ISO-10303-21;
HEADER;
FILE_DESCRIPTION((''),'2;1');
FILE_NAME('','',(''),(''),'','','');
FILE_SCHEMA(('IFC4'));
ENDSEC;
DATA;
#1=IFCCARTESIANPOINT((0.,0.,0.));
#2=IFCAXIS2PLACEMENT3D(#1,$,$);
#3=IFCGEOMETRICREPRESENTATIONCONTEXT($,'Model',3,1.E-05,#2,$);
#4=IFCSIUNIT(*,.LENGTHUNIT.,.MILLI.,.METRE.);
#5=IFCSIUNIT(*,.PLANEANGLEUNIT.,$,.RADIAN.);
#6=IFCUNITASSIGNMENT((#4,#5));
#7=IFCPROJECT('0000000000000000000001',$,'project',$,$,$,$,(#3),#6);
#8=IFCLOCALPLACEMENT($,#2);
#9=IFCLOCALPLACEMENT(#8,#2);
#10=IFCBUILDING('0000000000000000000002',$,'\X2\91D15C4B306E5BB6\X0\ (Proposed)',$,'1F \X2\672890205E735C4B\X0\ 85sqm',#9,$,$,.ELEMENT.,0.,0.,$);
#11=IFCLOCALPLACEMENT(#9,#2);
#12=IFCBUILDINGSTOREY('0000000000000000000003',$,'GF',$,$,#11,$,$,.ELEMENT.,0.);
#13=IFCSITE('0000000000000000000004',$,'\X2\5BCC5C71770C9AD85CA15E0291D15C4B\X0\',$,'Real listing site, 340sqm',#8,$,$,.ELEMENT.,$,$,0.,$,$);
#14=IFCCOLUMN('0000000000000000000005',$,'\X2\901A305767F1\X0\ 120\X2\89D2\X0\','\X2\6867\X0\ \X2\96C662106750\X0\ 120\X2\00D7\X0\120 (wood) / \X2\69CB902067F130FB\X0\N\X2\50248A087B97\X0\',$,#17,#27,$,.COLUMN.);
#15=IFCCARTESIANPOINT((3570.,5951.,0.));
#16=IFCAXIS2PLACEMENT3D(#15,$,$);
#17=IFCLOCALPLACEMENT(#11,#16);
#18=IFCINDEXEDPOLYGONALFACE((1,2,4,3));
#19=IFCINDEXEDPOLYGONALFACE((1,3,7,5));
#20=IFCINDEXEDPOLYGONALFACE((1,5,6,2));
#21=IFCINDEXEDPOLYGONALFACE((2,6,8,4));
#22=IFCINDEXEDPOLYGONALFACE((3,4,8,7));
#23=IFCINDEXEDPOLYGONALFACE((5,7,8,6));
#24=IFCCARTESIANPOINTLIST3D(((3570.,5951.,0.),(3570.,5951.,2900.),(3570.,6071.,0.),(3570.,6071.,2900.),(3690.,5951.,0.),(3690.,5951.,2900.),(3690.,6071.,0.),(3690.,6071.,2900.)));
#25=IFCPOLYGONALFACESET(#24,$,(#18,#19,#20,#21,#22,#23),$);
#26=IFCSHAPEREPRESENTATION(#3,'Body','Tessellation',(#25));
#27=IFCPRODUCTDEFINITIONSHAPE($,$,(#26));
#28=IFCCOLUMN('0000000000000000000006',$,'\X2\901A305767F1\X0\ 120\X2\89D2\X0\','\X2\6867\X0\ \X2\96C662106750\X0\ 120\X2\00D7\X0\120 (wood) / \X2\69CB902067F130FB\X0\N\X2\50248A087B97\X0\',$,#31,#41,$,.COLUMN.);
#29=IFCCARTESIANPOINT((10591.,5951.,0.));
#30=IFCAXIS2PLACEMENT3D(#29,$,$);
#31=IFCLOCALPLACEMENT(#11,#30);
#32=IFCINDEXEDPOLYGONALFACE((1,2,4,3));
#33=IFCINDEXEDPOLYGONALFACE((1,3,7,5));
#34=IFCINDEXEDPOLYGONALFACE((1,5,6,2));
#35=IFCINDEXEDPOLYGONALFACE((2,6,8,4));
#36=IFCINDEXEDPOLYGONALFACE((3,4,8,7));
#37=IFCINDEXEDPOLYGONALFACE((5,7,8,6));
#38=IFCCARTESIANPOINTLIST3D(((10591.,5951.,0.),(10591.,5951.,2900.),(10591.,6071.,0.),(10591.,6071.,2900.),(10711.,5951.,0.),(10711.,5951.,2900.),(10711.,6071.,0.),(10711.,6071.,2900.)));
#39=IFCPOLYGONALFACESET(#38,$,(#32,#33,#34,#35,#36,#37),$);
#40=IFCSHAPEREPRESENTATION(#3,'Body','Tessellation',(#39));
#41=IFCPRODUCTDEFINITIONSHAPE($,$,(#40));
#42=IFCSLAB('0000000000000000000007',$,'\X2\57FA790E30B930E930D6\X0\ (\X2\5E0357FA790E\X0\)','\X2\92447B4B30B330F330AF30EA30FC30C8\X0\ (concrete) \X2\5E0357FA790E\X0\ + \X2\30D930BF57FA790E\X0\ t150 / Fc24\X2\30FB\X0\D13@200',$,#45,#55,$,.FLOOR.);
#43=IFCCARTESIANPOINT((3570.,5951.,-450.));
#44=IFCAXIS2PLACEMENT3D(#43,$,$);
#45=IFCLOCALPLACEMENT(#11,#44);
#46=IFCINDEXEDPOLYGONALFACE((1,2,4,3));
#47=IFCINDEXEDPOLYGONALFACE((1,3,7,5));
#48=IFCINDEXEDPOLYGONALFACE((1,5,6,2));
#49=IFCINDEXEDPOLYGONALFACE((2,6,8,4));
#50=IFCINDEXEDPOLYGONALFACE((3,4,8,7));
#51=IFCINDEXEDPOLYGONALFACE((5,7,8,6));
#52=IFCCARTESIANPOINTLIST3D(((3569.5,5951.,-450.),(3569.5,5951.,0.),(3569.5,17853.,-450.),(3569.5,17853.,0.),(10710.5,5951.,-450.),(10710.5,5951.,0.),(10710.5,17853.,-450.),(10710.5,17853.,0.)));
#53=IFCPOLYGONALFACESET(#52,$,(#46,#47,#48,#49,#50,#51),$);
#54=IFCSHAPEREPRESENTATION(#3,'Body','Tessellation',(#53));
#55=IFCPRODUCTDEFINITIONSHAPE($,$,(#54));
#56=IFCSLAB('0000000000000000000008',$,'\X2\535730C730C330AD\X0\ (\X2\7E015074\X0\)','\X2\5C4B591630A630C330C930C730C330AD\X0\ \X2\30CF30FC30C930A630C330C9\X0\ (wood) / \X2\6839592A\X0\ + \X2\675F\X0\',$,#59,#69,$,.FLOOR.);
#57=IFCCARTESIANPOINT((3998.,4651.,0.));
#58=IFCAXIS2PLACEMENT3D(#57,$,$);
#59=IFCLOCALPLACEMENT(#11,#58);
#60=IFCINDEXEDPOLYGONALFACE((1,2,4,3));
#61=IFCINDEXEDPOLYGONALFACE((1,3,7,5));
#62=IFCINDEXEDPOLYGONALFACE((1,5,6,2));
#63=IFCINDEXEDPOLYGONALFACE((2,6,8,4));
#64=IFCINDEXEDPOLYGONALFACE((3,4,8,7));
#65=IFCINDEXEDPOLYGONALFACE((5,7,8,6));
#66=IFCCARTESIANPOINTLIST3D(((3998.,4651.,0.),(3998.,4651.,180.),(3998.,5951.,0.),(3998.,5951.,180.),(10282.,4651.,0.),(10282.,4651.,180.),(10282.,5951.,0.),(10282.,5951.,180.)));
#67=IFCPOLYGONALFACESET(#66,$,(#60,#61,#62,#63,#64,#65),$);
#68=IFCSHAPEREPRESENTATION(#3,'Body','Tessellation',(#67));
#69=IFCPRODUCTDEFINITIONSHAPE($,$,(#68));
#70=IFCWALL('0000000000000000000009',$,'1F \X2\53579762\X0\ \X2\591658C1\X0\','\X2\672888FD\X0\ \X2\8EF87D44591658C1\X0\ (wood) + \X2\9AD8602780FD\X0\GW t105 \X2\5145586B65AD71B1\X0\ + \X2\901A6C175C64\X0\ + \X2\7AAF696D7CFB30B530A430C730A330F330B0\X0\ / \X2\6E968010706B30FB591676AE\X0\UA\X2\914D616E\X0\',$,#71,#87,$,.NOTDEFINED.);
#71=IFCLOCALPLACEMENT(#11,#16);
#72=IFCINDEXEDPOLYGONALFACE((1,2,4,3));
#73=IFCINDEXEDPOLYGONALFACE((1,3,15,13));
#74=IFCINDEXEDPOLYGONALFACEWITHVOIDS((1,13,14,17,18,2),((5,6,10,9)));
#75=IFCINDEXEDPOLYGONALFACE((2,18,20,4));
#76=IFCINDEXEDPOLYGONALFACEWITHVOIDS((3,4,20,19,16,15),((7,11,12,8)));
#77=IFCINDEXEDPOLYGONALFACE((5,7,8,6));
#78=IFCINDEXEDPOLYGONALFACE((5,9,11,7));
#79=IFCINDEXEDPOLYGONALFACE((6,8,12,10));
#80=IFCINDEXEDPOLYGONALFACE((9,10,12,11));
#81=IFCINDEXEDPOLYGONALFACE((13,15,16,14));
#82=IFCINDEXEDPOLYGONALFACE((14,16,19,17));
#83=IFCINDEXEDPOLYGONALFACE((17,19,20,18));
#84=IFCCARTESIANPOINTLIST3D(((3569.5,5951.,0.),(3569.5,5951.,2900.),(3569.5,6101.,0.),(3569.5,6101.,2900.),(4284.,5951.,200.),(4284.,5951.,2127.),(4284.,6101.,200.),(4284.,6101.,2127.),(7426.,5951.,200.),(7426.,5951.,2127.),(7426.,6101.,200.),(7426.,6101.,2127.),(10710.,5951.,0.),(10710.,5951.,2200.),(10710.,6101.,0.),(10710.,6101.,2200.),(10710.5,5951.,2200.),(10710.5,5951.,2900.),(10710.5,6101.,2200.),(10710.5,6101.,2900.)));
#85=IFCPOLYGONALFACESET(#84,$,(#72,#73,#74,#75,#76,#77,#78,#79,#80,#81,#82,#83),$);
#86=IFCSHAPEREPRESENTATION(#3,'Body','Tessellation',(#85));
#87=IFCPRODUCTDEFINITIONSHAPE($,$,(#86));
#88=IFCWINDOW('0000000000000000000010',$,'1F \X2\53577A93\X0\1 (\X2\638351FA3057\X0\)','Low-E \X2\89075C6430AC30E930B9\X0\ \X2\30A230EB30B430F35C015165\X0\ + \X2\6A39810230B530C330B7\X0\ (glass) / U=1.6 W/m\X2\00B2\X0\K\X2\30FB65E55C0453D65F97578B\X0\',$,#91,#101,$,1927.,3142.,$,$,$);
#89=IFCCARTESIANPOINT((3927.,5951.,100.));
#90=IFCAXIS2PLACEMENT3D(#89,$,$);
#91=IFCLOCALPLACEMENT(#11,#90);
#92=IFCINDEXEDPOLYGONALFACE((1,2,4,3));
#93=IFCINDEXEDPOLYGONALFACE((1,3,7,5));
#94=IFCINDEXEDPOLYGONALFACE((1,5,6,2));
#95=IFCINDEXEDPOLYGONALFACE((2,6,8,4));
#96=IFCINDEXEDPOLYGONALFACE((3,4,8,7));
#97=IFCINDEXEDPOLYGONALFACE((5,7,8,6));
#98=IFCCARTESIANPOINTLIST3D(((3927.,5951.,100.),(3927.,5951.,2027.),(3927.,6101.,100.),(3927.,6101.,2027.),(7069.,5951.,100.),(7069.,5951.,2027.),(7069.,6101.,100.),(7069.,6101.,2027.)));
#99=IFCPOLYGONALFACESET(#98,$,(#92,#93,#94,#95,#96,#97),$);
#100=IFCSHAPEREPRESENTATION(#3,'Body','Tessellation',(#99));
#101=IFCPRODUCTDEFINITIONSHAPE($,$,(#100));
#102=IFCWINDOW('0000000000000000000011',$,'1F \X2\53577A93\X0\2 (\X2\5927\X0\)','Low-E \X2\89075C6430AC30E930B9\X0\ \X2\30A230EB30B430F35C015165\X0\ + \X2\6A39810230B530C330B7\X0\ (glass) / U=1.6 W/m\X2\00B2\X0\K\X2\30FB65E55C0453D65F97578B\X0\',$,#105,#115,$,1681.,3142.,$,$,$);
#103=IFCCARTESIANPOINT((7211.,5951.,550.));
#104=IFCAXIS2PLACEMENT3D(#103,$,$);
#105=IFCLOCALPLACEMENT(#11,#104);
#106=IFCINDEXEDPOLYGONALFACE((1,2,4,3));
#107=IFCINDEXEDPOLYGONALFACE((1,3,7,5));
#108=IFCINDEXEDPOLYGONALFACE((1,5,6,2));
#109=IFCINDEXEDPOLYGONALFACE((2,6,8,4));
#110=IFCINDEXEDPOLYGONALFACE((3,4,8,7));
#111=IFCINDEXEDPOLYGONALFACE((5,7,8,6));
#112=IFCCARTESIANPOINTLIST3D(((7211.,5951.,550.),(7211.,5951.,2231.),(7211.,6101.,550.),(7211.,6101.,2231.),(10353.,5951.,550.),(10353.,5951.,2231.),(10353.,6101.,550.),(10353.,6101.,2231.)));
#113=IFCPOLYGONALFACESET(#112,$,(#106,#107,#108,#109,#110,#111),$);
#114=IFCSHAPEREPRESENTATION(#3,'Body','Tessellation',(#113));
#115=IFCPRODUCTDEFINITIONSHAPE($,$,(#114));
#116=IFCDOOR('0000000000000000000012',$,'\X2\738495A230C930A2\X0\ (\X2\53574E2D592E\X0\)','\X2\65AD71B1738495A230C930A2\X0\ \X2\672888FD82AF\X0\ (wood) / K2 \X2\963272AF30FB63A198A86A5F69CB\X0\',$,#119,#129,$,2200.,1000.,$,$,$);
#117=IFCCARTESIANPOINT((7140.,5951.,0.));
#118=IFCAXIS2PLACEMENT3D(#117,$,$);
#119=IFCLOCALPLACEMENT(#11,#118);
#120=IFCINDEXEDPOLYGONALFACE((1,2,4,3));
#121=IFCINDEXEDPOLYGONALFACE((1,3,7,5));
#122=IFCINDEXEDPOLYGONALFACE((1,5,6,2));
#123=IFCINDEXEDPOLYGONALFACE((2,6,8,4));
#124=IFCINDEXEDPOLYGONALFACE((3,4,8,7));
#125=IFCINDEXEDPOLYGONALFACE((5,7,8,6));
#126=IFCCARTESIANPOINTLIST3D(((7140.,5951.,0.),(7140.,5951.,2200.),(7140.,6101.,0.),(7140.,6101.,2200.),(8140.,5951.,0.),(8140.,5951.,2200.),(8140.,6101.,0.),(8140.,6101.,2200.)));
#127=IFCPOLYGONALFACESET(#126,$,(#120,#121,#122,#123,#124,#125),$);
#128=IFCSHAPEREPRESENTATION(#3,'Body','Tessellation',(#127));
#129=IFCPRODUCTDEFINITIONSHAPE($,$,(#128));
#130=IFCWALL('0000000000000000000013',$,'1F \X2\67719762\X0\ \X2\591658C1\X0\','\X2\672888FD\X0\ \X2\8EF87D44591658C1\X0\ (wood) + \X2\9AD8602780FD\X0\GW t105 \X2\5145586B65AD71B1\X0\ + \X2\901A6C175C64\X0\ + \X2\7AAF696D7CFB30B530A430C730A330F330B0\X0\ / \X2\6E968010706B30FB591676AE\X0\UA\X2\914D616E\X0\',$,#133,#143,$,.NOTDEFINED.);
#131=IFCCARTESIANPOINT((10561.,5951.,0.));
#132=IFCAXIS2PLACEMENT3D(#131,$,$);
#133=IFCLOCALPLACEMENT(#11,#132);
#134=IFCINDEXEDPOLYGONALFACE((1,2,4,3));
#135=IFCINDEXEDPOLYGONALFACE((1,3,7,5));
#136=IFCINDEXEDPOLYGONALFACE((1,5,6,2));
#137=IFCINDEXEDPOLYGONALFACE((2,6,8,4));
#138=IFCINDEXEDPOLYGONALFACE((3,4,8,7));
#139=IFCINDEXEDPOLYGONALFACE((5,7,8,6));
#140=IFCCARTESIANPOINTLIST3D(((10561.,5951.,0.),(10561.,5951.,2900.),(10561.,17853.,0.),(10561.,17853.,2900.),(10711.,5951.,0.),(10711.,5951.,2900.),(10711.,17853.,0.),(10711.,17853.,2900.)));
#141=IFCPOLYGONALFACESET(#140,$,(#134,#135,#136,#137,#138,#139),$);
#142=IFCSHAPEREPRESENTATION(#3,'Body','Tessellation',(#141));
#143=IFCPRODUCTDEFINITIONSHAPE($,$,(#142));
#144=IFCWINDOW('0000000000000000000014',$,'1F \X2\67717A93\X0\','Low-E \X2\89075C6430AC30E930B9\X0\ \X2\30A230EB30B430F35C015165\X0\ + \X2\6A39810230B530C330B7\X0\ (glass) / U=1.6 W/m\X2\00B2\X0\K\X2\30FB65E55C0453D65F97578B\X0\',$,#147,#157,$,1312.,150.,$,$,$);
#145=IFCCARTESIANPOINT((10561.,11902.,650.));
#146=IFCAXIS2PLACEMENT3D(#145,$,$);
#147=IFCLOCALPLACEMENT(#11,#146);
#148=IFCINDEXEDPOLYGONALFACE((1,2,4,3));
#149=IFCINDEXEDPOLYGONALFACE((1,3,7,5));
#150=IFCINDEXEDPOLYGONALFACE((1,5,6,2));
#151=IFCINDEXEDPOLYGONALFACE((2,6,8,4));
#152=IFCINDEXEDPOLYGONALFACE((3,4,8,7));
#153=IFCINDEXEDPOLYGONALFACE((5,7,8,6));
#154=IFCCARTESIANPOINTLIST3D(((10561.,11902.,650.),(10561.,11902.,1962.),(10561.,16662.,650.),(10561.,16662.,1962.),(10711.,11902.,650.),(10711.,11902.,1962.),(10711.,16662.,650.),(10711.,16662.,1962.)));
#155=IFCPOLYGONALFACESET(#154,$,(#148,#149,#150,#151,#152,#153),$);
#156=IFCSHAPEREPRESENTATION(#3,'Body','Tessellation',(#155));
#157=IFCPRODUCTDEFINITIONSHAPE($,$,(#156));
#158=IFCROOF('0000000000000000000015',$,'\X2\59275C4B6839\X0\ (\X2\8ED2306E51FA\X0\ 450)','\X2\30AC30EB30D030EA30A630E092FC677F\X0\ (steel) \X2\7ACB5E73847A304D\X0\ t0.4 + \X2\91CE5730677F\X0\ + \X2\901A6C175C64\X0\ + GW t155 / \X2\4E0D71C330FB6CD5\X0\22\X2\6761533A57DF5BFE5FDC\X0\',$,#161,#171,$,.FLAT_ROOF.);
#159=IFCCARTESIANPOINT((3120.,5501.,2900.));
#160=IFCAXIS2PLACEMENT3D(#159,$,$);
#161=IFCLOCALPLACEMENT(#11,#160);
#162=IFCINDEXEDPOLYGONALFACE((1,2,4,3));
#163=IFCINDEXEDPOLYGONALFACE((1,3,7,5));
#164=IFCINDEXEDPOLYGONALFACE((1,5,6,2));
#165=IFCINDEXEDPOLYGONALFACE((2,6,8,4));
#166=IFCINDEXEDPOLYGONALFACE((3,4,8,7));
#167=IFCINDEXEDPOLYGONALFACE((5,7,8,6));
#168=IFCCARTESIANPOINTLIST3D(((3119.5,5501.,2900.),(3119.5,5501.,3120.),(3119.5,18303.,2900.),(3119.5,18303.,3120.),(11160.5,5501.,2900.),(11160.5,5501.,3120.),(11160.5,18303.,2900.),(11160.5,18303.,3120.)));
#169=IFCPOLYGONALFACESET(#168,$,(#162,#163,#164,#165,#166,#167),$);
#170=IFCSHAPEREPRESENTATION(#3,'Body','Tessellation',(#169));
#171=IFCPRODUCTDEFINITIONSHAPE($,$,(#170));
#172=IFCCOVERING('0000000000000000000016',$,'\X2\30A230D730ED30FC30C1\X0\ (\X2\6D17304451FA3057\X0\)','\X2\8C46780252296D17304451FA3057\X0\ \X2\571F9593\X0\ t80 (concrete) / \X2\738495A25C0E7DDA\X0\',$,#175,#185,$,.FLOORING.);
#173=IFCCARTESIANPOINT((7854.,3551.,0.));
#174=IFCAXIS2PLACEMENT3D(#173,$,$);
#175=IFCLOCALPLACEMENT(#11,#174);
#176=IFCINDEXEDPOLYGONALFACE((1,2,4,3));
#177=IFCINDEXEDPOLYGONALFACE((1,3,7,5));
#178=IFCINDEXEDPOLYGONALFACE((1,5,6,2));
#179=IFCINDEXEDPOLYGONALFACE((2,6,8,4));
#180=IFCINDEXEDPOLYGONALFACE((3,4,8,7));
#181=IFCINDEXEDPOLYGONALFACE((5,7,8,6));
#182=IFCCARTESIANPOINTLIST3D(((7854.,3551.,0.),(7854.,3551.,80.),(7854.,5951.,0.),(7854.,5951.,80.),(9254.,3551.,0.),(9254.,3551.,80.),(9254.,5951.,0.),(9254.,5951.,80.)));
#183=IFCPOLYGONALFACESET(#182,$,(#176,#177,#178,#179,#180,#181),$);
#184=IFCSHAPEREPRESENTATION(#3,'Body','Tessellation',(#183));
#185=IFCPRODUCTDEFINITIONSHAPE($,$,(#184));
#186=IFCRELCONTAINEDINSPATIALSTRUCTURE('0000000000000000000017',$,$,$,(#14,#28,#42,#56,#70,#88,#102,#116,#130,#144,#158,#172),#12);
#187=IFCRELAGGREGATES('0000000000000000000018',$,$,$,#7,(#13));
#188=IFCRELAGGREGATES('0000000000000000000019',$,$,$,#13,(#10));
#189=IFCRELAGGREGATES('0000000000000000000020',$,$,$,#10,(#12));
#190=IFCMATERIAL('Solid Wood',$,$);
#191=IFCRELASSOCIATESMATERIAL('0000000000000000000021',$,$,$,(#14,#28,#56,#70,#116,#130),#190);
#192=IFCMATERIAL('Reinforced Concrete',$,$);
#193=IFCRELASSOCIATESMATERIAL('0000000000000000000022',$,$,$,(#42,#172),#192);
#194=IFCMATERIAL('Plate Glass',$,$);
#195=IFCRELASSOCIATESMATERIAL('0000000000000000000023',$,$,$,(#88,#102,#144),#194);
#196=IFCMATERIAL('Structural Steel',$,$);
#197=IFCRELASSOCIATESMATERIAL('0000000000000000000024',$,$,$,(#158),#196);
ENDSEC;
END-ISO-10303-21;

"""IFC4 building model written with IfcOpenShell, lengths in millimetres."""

from ifc_helpers import new_model, si_unit, frame, frame_2d, origin, place, context, project, spatial, rectangle, extrude, material, element, fill, save


model = new_model("IFC4")

# Units and contexts
model_context = context("Model", 3, precision=1e-05, world=origin())
ifc_project = project(units=[si_unit("LENGTHUNIT", "METRE", prefix="MILLI"), si_unit("PLANEANGLEUNIT", "RADIAN")], contexts=[model_context])

# Site, building, storey
site_placement = place(None, origin())
site = spatial("IfcSite", under=ifc_project, at=site_placement, Name="富山県高岡市金屋", ObjectType="Real listing site, 340sqm", CompositionType="ELEMENT", RefElevation=0.0)
building_placement = place(site_placement, origin())
building = spatial("IfcBuilding", under=site, at=building_placement, Name="金屋の家 (Proposed)", ObjectType="1F 木造平屋 85sqm", CompositionType="ELEMENT", ElevationOfRefHeight=0.0, ElevationOfTerrain=0.0)
storey_placement = place(building_placement, origin())
storey = spatial("IfcBuildingStorey", under=building, at=storey_placement, Name="GF", CompositionType="ELEMENT", Elevation=0.0)

# Columns
ifc_material_1 = material(Name="Solid Wood")
column_1_placement = place(storey_placement, frame((3570.0, 5951.0, 0.0)))
element("IfcColumn", 1, at=column_1_placement, inside=storey, material=ifc_material_1, Name="通し柱 120角", Description="桧 集成材 120×120 (wood) / 構造柱・N値計算", PredefinedType="COLUMN", context=model_context, shape_type="SweptSolid", body=[
    extrude(rectangle(XDim=120.0, YDim=120.0, at=frame_2d((60.0, 60.0))), frame((3570.0, 5951.0, 0.0)), (0.0, 0.0, 1.0), 2900.0),
])
column_2_placement = place(storey_placement, frame((10591.0, 5951.0, 0.0)))
element("IfcColumn", 2, at=column_2_placement, inside=storey, material=ifc_material_1, Name="通し柱 120角", Description="桧 集成材 120×120 (wood) / 構造柱・N値計算", PredefinedType="COLUMN", context=model_context, shape_type="SweptSolid", body=[
    extrude(rectangle(XDim=120.0, YDim=120.0, at=frame_2d((60.0, 60.0))), frame((10591.0, 5951.0, 0.0)), (0.0, 0.0, 1.0), 2900.0),
])

# Slabs
ifc_material_2 = material(Name="Reinforced Concrete")
slab_1_placement = place(storey_placement, frame((3570.0, 5951.0, -450.0)))
element("IfcSlab", 3, at=slab_1_placement, inside=storey, material=ifc_material_2, Name="基礎スラブ (布基礎)", Description="鉄筋コンクリート (concrete) 布基礎 + ベタ基礎 t150 / Fc24・D13@200", PredefinedType="FLOOR", context=model_context, shape_type="SweptSolid", body=[
    extrude(rectangle(XDim=7141.0, YDim=11902.0, at=frame_2d((3570.0, 5951.0))), frame((3570.0, 5951.0, -450.0)), (0.0, 0.0, 1.0), 450.0),
])
slab_2_placement = place(storey_placement, frame((3998.0, 4651.0, 0.0)))
element("IfcSlab", 4, at=slab_2_placement, inside=storey, material=ifc_material_1, Name="南デッキ (縁側)", Description="屋外ウッドデッキ ハードウッド (wood) / 根太 + 束", PredefinedType="FLOOR", context=model_context, shape_type="SweptSolid", body=[
    extrude(rectangle(XDim=6284.0, YDim=1300.0, at=frame_2d((3142.0, 650.0))), frame((3998.0, 4651.0, 0.0)), (0.0, 0.0, 1.0), 180.0),
])

# Wall, openings, windows, door
wall_1_placement = place(storey_placement, frame((3570.0, 5951.0, 0.0)))
wall_1 = element("IfcWall", 5, at=wall_1_placement, inside=storey, material=ifc_material_1, Name="1F 南面 外壁", Description="木製 軸組外壁 (wood) + 高性能GW t105 充填断熱 + 通気層 + 窯業系サイディング / 準耐火・外皮UA配慮", PredefinedType="NOTDEFINED", context=model_context, shape_type="SweptSolid", body=[
    extrude(rectangle(XDim=7141.0, YDim=150.0, at=frame_2d((3570.0, 75.0))), frame((3570.0, 5951.0, 0.0)), (0.0, 0.0, 1.0), 2900.0),
])
opening_1_placement = place(storey_placement, frame((3927.0, 5951.0, 100.0)))
opening_1 = element("IfcOpeningElement", 6, at=opening_1_placement, cuts=wall_1, PredefinedType="NOTDEFINED", context=model_context, shape_type="SweptSolid", body=[
    extrude(rectangle(XDim=3142.0, YDim=150.0, at=frame_2d((1571.0, 75.0))), frame((3927.0, 5951.0, 100.0)), (0.0, 0.0, 1.0), 1927.0),
])
opening_2_placement = place(storey_placement, frame((7211.0, 5951.0, 550.0)))
opening_2 = element("IfcOpeningElement", 7, at=opening_2_placement, cuts=wall_1, PredefinedType="NOTDEFINED", context=model_context, shape_type="SweptSolid", body=[
    extrude(rectangle(XDim=3142.0, YDim=150.0, at=frame_2d((1571.0, 75.0))), frame((7211.0, 5951.0, 550.0)), (0.0, 0.0, 1.0), 1681.0),
])
opening_3_placement = place(storey_placement, frame((7140.0, 5951.0, 0.0)))
opening_3 = element("IfcOpeningElement", 8, at=opening_3_placement, cuts=wall_1, PredefinedType="NOTDEFINED", context=model_context, shape_type="SweptSolid", body=[
    extrude(rectangle(XDim=1000.0, YDim=150.0, at=frame_2d((500.0, 75.0))), frame((7140.0, 5951.0, 0.0)), (0.0, 0.0, 1.0), 2200.0),
])
ifc_material_3 = material(Name="Plate Glass")
window_1_placement = place(storey_placement, frame((3927.0, 5951.0, 100.0)))
window_1 = element("IfcWindow", 9, at=window_1_placement, inside=storey, material=ifc_material_3, Name="1F 南窓1 (掃出し)", Description="Low-E 複層ガラス アルゴン封入 + 樹脂サッシ (glass) / U=1.6 W/m²K・日射取得型", OverallHeight=1927.0, OverallWidth=3142.0, context=model_context, shape_type="SweptSolid", body=[
    extrude(rectangle(XDim=3142.0, YDim=150.0, at=frame_2d((1571.0, 75.0))), frame((3927.0, 5951.0, 100.0)), (0.0, 0.0, 1.0), 1927.0),
])
fill(opening_1, window_1)
window_2_placement = place(storey_placement, frame((7211.0, 5951.0, 550.0)))
window_2 = element("IfcWindow", 10, at=window_2_placement, inside=storey, material=ifc_material_3, Name="1F 南窓2 (大)", Description="Low-E 複層ガラス アルゴン封入 + 樹脂サッシ (glass) / U=1.6 W/m²K・日射取得型", OverallHeight=1681.0, OverallWidth=3142.0, context=model_context, shape_type="SweptSolid", body=[
    extrude(rectangle(XDim=3142.0, YDim=150.0, at=frame_2d((1571.0, 75.0))), frame((7211.0, 5951.0, 550.0)), (0.0, 0.0, 1.0), 1681.0),
])
fill(opening_2, window_2)
door_placement = place(storey_placement, frame((7140.0, 5951.0, 0.0)))
door = element("IfcDoor", 11, at=door_placement, inside=storey, material=ifc_material_1, Name="玄関ドア (南中央)", Description="断熱玄関ドア 木製芯 (wood) / K2 防犯・採風機構", OverallHeight=2200.0, OverallWidth=1000.0, context=model_context, shape_type="SweptSolid", body=[
    extrude(rectangle(XDim=1000.0, YDim=150.0, at=frame_2d((500.0, 75.0))), frame((7140.0, 5951.0, 0.0)), (0.0, 0.0, 1.0), 2200.0),
])
fill(opening_3, door)

# Wall, opening, window
wall_2_placement = place(storey_placement, frame((10561.0, 5951.0, 0.0)))
wall_2 = element("IfcWall", 12, at=wall_2_placement, inside=storey, material=ifc_material_1, Name="1F 東面 外壁", Description="木製 軸組外壁 (wood) + 高性能GW t105 充填断熱 + 通気層 + 窯業系サイディング / 準耐火・外皮UA配慮", PredefinedType="NOTDEFINED", context=model_context, shape_type="SweptSolid", body=[
    extrude(rectangle(XDim=150.0, YDim=11902.0, at=frame_2d((75.0, 5951.0))), frame((10561.0, 5951.0, 0.0)), (0.0, 0.0, 1.0), 2900.0),
])
opening_4_placement = place(storey_placement, frame((10561.0, 11902.0, 650.0)))
opening_4 = element("IfcOpeningElement", 13, at=opening_4_placement, cuts=wall_2, PredefinedType="NOTDEFINED", context=model_context, shape_type="SweptSolid", body=[
    extrude(rectangle(XDim=150.0, YDim=4760.0, at=frame_2d((75.0, 2380.0))), frame((10561.0, 11902.0, 650.0)), (0.0, 0.0, 1.0), 1312.0),
])
window_3_placement = place(storey_placement, frame((10561.0, 11902.0, 650.0)))
window_3 = element("IfcWindow", 14, at=window_3_placement, inside=storey, material=ifc_material_3, Name="1F 東窓", Description="Low-E 複層ガラス アルゴン封入 + 樹脂サッシ (glass) / U=1.6 W/m²K・日射取得型", OverallHeight=1312.0, OverallWidth=150.0, context=model_context, shape_type="SweptSolid", body=[
    extrude(rectangle(XDim=150.0, YDim=4760.0, at=frame_2d((75.0, 2380.0))), frame((10561.0, 11902.0, 650.0)), (0.0, 0.0, 1.0), 1312.0),
])
fill(opening_4, window_3)

# Roof
ifc_material_4 = material(Name="Structural Steel")
roof_placement = place(storey_placement, frame((3120.0, 5501.0, 2900.0)))
element("IfcRoof", 15, at=roof_placement, inside=storey, material=ifc_material_4, Name="大屋根 (軒の出 450)", Description="ガルバリウム鋼板 (steel) 立平葺き t0.4 + 野地板 + 通気層 + GW t155 / 不燃・法22条区域対応", PredefinedType="FLAT_ROOF", context=model_context, shape_type="SweptSolid", body=[
    extrude(rectangle(XDim=8041.0, YDim=12802.0, at=frame_2d((4020.0, 6401.0))), frame((3120.0, 5501.0, 2900.0)), (0.0, 0.0, 1.0), 220.0),
])

# Covering
covering_1_placement = place(storey_placement, frame((7854.0, 3551.0, 0.0)))
element("IfcCovering", 16, at=covering_1_placement, inside=storey, material=ifc_material_2, Name="アプローチ (洗い出し)", Description="豆砂利洗い出し 土間 t80 (concrete) / 玄関導線", PredefinedType="FLOORING", context=model_context, shape_type="SweptSolid", body=[
    extrude(rectangle(XDim=1400.0, YDim=2400.0, at=frame_2d((700.0, 1200.0))), frame((7854.0, 3551.0, 0.0)), (0.0, 0.0, 1.0), 80.0),
])

save(model, "model.ifc")
